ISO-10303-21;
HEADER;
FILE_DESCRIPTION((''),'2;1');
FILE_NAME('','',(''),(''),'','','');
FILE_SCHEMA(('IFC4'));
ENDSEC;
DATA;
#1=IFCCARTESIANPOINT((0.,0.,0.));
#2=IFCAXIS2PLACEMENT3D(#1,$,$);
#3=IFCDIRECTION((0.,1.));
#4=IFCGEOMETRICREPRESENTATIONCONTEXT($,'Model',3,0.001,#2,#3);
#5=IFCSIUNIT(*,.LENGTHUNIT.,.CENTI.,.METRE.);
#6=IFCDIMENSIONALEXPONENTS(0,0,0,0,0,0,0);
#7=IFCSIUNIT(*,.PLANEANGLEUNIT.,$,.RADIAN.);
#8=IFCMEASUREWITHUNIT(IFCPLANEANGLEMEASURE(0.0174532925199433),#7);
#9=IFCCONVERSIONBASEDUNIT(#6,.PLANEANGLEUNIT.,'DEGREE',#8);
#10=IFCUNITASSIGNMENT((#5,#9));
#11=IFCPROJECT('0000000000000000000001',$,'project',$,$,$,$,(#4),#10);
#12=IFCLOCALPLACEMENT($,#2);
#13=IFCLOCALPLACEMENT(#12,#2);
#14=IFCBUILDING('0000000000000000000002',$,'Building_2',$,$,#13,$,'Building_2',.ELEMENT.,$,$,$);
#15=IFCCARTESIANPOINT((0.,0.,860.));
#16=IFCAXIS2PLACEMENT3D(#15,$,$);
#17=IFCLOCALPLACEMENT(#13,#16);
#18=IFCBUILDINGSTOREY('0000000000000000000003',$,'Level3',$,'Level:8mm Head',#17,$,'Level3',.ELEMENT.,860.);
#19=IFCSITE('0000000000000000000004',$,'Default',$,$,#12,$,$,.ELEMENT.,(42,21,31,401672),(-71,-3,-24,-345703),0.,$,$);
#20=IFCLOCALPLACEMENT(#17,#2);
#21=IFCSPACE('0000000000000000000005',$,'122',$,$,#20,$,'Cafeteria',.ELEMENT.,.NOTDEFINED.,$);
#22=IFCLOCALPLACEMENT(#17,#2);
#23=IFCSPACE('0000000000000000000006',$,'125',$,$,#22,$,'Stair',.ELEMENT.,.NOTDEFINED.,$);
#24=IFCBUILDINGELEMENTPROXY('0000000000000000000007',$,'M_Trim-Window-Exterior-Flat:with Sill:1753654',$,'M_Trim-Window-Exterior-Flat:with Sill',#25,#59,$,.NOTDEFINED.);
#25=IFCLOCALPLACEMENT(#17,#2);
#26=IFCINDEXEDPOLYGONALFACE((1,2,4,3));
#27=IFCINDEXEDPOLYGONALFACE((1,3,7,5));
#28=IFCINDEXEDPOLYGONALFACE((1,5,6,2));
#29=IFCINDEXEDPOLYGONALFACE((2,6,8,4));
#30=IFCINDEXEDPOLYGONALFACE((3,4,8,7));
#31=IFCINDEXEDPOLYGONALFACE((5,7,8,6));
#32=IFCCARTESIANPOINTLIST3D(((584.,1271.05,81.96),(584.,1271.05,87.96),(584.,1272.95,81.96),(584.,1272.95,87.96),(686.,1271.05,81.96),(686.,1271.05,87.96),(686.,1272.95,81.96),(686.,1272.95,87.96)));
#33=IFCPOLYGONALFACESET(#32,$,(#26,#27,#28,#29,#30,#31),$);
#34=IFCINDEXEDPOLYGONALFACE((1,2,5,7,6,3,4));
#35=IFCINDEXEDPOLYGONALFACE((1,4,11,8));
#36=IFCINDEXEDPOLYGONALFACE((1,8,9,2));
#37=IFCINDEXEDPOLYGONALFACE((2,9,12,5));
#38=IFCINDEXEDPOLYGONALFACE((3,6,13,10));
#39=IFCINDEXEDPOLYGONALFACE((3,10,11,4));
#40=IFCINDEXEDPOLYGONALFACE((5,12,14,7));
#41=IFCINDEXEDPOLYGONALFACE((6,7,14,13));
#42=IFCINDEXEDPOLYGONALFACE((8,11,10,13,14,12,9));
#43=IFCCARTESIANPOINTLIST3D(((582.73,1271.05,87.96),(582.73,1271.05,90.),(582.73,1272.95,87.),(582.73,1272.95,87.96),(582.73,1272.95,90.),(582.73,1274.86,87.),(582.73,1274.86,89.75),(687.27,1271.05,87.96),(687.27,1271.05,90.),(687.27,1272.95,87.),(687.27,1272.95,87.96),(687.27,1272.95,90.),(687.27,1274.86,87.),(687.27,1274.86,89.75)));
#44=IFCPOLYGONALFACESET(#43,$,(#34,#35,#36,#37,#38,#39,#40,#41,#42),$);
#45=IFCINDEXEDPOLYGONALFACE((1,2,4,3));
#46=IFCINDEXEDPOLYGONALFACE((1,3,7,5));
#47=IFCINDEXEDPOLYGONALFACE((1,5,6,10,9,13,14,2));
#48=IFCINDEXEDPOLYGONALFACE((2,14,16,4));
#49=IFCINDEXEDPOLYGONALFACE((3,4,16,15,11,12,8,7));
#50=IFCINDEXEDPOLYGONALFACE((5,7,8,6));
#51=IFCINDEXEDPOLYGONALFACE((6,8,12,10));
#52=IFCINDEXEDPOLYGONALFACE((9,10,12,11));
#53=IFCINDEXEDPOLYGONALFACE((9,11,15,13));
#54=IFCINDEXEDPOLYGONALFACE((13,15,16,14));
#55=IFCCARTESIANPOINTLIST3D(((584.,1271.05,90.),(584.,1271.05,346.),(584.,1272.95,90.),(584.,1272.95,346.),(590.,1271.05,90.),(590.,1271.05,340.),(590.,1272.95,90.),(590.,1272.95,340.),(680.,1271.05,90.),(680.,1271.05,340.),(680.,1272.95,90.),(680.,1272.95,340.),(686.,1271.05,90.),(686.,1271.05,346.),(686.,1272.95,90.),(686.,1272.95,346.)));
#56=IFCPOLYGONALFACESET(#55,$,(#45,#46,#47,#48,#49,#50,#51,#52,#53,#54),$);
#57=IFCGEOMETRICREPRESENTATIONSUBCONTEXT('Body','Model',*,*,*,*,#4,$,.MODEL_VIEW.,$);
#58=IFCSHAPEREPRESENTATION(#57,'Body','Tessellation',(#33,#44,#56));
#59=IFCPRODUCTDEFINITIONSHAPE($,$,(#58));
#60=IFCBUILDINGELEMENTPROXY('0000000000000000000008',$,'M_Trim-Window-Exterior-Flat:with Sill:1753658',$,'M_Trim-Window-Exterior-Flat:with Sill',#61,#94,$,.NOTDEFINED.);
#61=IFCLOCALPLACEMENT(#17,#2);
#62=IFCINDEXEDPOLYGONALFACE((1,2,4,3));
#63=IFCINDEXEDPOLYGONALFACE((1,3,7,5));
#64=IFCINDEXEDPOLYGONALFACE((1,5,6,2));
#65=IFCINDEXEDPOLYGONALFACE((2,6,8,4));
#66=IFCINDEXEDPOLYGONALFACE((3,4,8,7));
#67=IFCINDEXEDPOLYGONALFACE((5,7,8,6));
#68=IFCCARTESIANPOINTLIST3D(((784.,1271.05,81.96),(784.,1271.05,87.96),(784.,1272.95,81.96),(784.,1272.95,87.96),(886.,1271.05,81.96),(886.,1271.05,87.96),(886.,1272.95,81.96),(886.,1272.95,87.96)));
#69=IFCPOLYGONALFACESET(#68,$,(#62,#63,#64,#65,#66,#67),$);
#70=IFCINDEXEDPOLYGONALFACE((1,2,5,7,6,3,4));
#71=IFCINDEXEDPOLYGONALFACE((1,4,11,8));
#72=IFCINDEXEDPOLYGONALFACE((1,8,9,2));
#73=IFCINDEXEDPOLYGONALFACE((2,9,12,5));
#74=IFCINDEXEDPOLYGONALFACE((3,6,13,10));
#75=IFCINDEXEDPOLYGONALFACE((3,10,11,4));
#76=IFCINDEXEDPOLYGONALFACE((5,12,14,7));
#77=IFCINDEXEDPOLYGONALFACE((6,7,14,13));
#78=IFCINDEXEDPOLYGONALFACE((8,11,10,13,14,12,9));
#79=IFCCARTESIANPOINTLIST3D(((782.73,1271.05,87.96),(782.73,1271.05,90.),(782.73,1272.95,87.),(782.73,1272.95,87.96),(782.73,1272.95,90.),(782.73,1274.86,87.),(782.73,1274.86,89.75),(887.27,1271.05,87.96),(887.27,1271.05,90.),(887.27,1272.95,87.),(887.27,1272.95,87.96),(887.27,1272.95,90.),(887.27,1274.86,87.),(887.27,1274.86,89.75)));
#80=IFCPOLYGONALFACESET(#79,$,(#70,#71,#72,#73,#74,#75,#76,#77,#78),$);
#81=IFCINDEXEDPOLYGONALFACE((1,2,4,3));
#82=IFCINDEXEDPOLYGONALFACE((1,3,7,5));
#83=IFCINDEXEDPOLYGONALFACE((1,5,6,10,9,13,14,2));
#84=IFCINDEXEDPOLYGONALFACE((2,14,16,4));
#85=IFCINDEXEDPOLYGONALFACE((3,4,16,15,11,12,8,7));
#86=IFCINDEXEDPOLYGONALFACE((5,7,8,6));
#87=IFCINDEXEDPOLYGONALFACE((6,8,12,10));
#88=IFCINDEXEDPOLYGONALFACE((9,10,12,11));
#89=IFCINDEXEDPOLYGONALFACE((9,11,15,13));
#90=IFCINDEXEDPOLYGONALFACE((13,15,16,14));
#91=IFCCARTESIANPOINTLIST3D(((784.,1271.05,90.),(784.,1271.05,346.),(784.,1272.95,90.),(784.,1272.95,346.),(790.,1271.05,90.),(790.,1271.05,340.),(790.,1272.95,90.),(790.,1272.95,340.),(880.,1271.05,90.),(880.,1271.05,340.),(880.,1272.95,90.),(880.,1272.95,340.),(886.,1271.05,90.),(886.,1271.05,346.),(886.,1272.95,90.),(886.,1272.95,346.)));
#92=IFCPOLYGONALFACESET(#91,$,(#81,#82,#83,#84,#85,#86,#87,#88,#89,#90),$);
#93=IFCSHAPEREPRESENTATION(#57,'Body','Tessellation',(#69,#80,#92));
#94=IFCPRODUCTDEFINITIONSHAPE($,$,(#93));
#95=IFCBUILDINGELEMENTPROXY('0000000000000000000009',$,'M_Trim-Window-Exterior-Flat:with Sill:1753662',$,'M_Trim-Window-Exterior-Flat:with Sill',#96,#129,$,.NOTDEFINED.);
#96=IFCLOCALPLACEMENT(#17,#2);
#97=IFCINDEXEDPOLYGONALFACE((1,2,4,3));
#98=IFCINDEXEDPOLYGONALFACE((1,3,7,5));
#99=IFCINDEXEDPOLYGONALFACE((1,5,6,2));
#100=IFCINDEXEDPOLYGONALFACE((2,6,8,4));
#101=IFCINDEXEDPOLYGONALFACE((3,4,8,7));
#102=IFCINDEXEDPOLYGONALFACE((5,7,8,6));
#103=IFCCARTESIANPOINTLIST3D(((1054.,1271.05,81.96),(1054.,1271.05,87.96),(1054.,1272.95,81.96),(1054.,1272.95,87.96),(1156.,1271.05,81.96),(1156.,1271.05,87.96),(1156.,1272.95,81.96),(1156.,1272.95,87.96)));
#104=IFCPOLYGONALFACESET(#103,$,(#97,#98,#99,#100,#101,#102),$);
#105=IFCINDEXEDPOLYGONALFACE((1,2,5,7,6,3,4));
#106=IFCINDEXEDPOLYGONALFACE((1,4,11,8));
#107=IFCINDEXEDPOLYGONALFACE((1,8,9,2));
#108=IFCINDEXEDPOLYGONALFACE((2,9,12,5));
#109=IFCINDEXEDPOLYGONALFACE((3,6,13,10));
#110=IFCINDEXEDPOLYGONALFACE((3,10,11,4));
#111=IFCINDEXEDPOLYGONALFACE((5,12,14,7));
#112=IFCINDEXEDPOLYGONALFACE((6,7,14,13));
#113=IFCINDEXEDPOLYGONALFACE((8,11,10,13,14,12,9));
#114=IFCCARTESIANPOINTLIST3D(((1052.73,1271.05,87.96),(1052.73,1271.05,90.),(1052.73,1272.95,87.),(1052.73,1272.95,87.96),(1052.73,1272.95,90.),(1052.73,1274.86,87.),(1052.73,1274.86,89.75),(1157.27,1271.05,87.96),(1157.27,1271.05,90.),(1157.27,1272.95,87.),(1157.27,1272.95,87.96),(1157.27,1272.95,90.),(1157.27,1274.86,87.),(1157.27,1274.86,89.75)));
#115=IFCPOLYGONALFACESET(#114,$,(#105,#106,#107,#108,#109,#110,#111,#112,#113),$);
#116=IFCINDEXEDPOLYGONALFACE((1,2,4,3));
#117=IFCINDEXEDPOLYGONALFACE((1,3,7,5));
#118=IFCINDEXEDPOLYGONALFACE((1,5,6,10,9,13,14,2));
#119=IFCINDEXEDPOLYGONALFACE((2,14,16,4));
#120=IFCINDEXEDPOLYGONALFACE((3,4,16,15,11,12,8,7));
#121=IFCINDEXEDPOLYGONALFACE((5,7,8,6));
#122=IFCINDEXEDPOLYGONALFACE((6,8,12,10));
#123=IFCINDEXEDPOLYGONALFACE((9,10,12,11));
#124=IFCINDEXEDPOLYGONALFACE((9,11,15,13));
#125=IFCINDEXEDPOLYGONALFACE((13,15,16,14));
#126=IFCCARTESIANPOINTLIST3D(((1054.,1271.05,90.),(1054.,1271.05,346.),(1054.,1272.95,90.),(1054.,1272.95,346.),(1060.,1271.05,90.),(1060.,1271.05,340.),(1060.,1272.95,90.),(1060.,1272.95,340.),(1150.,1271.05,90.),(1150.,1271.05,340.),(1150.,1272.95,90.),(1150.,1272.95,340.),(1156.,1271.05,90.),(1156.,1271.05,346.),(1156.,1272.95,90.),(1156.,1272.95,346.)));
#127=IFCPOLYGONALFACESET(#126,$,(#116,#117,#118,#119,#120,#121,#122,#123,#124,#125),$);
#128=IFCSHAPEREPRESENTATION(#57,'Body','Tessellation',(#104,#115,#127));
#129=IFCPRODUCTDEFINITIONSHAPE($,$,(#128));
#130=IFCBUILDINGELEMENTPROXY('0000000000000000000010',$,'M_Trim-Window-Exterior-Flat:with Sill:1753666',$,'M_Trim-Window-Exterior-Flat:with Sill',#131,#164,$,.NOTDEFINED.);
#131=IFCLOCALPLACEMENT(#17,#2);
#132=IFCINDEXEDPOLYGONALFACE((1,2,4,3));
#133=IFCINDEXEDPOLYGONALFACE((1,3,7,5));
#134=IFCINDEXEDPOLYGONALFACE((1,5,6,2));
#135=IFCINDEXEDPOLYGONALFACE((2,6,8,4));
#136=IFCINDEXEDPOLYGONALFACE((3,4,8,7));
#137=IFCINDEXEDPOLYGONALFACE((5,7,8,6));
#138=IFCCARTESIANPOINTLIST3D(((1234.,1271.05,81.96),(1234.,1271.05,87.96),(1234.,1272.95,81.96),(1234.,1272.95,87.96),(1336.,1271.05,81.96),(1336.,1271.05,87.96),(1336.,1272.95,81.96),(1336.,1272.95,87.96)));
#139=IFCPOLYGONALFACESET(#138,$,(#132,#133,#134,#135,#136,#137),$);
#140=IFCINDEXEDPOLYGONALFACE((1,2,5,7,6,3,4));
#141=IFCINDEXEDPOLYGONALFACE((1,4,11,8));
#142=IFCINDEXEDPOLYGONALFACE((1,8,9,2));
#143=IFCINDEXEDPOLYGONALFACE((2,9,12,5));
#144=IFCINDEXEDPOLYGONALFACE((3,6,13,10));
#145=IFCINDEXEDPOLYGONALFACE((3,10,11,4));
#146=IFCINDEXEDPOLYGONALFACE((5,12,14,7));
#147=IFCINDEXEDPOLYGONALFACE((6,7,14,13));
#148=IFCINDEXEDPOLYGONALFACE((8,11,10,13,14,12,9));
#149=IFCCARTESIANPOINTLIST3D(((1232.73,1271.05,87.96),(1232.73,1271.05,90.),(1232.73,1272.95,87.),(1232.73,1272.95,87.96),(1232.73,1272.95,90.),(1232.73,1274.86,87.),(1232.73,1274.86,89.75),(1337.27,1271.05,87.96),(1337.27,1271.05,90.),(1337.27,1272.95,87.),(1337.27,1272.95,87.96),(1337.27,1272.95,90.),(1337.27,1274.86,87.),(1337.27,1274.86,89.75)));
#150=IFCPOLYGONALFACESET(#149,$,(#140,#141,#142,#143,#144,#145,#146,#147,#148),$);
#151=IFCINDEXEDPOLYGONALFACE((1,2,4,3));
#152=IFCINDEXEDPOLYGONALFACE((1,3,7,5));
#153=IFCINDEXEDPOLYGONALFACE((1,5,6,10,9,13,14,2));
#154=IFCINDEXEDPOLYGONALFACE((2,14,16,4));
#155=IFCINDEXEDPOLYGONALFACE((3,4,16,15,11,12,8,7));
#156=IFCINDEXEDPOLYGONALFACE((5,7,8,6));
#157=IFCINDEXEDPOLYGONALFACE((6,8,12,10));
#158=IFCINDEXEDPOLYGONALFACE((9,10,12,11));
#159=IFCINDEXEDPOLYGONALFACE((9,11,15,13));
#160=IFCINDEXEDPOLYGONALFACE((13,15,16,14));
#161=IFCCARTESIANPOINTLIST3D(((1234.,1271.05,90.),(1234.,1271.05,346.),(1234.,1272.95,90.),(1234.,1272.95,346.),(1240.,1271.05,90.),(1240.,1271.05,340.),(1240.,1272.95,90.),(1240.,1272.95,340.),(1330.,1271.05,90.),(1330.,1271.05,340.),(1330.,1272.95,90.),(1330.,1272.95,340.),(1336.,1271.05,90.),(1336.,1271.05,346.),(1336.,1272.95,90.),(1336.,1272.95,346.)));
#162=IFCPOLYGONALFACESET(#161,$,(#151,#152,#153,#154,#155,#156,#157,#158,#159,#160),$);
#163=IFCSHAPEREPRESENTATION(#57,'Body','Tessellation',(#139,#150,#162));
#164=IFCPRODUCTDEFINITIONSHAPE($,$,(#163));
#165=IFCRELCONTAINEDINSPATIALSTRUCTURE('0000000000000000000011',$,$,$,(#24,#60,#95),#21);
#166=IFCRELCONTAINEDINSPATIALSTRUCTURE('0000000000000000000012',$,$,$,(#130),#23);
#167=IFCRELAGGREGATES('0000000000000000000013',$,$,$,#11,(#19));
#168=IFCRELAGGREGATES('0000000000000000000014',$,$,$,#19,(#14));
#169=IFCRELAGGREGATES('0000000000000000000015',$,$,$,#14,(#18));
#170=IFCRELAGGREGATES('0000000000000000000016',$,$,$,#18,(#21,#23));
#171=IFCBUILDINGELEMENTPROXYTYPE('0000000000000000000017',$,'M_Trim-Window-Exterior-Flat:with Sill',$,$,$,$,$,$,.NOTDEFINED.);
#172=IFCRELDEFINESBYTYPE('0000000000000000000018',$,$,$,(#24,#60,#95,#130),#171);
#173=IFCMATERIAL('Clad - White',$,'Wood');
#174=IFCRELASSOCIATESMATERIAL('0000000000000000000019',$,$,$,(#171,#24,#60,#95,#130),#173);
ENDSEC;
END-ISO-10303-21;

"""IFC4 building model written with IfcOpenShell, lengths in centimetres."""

from ifc_helpers import new_model, entity, si_unit, converted_unit, direction, frame, origin, place, context, subcontext, project, spatial, indexed_curve, outline, extrude, source, transform, mapped, material, type_object, type_shapes, element, save


model = new_model("IFC4")

# Units and contexts
model_context = context("Model", 3, precision=0.001, world=origin(), true_north=direction((0.0, 1.0)))
body_context = subcontext(model_context, "Body", "Model", "MODEL_VIEW")
ifc_project = project(units=[si_unit("LENGTHUNIT", "METRE", prefix="CENTI"), converted_unit("PLANEANGLEUNIT", "DEGREE", entity("IfcPlaneAngleMeasure", 0.0174532925199433), si_unit("PLANEANGLEUNIT", "RADIAN"), dimensions=[0, 0, 0, 0, 0, 0, 0])], contexts=[model_context])

# Site, building, storey
site_placement = place(None, origin())
site = spatial("IfcSite", under=ifc_project, at=site_placement, Name="Default", CompositionType="ELEMENT", RefLatitude=(42, 21, 31, 401672), RefLongitude=(-71, -3, -24, -345703), RefElevation=0.0)
building_placement = place(site_placement, origin())
building = spatial("IfcBuilding", under=site, at=building_placement, Name="Building_2", LongName="Building_2", CompositionType="ELEMENT")
storey_placement = place(building_placement, frame((0.0, 0.0, 860.0)))
storey = spatial("IfcBuildingStorey", under=building, at=storey_placement, Name="Level3", ObjectType="Level:8mm Head", LongName="Level3", CompositionType="ELEMENT", Elevation=860.0)

# Shared definitions
ifc_material_1 = material(Name="Clad - White", Category="Wood")

# Shared definitions
space_1_placement = place(storey_placement, origin())
space_1 = spatial("IfcSpace", under=storey, at=space_1_placement, Name="122", LongName="Cafeteria", CompositionType="ELEMENT", PredefinedType="NOTDEFINED")

# Building element proxies
building_element_proxy_type_1 = type_object("IfcBuildingElementProxyType", Name="M_Trim-Window-Exterior-Flat:with Sill", PredefinedType="NOTDEFINED", material=ifc_material_1)
shared_shape_1 = source(origin(), body_context, "Body", "SweptSolid", [
    extrude(outline(indexed_curve([(-51.0, -3.0), (51.0, -3.0), (51.0, 3.0), (-51.0, 3.0), (-51.0, -3.0)], self_intersect=False)), frame((0.0, -255.04, 0.0), z_axis=(0.0, 0.0, 1.0), x_axis=(-1.0, 0.0, 0.0)), (0.0, 0.0, 1.0), 1.91),
    extrude(outline(indexed_curve([(-1.9, -1.52), (0.0, -1.52), (0.0, -0.57), (1.9, -0.57), (1.9, 1.48), (0.0, 1.48), (-1.9, 1.23), (-1.9, -1.52)], self_intersect=False)), frame((-52.27, -251.48, 1.9), z_axis=(1.0, 0.0, 0.0), x_axis=(0.0, 0.0, -1.0)), (0.0, 0.0, 1.0), 104.54),
    extrude(outline(indexed_curve([(-129.5, -51.0), (126.5, -51.0), (126.5, -45.0), (-123.5, -45.0), (-123.5, 45.0), (126.5, 45.0), (126.5, 51.0), (-129.5, 51.0), (-129.5, -51.0)], self_intersect=False)), frame((0.0, -123.5, 0.0), z_axis=(0.0, 0.0, 1.0), x_axis=(0.0, -1.0, 0.0)), (0.0, 0.0, 1.0), 1.91),
])
type_shapes(building_element_proxy_type_1, [shared_shape_1])
for number, where, z_axis, x_axis, name in (
    (1, (635.0, 1271.05, 340.0), (0.0, 1.0, 0.0), (-1.0, 0.0, 0.0), "M_Trim-Window-Exterior-Flat:with Sill:1753654"),
    (2, (835.0, 1271.05, 340.0), (0.0, 1.0, 0.0), (-1.0, 0.0, 0.0), "M_Trim-Window-Exterior-Flat:with Sill:1753658"),
    (3, (1105.0, 1271.05, 340.0), (0.0, 1.0, 0.0), (-1.0, 0.0, 0.0), "M_Trim-Window-Exterior-Flat:with Sill:1753662"),
):
    element("IfcBuildingElementProxy", number, at=place(space_1_placement, frame(where, z_axis=z_axis, x_axis=x_axis)), inside=space_1, type_object=building_element_proxy_type_1, material=ifc_material_1, Name=name, ObjectType="M_Trim-Window-Exterior-Flat:with Sill", PredefinedType="NOTDEFINED", context=body_context, shape_type="MappedRepresentation", body=[
        mapped(shared_shape_1, transform((0.0, 0.0, 0.0), scale=1.0)),
    ])

# Shared definitions
space_2_placement = place(storey_placement, origin())
space_2 = spatial("IfcSpace", under=storey, at=space_2_placement, Name="125", LongName="Stair", CompositionType="ELEMENT", PredefinedType="NOTDEFINED")

# Building element proxy
proxy_1_placement = place(space_2_placement, frame((1285.0, 1271.05, 340.0), z_axis=(0.0, 1.0, 0.0), x_axis=(-1.0, 0.0, 0.0)))
element("IfcBuildingElementProxy", 4, at=proxy_1_placement, inside=space_2, type_object=building_element_proxy_type_1, material=ifc_material_1, Name="M_Trim-Window-Exterior-Flat:with Sill:1753666", ObjectType="M_Trim-Window-Exterior-Flat:with Sill", PredefinedType="NOTDEFINED", context=body_context, shape_type="MappedRepresentation", body=[
    mapped(shared_shape_1, transform((0.0, 0.0, 0.0), scale=1.0)),
])

save(model, "model.ifc")
